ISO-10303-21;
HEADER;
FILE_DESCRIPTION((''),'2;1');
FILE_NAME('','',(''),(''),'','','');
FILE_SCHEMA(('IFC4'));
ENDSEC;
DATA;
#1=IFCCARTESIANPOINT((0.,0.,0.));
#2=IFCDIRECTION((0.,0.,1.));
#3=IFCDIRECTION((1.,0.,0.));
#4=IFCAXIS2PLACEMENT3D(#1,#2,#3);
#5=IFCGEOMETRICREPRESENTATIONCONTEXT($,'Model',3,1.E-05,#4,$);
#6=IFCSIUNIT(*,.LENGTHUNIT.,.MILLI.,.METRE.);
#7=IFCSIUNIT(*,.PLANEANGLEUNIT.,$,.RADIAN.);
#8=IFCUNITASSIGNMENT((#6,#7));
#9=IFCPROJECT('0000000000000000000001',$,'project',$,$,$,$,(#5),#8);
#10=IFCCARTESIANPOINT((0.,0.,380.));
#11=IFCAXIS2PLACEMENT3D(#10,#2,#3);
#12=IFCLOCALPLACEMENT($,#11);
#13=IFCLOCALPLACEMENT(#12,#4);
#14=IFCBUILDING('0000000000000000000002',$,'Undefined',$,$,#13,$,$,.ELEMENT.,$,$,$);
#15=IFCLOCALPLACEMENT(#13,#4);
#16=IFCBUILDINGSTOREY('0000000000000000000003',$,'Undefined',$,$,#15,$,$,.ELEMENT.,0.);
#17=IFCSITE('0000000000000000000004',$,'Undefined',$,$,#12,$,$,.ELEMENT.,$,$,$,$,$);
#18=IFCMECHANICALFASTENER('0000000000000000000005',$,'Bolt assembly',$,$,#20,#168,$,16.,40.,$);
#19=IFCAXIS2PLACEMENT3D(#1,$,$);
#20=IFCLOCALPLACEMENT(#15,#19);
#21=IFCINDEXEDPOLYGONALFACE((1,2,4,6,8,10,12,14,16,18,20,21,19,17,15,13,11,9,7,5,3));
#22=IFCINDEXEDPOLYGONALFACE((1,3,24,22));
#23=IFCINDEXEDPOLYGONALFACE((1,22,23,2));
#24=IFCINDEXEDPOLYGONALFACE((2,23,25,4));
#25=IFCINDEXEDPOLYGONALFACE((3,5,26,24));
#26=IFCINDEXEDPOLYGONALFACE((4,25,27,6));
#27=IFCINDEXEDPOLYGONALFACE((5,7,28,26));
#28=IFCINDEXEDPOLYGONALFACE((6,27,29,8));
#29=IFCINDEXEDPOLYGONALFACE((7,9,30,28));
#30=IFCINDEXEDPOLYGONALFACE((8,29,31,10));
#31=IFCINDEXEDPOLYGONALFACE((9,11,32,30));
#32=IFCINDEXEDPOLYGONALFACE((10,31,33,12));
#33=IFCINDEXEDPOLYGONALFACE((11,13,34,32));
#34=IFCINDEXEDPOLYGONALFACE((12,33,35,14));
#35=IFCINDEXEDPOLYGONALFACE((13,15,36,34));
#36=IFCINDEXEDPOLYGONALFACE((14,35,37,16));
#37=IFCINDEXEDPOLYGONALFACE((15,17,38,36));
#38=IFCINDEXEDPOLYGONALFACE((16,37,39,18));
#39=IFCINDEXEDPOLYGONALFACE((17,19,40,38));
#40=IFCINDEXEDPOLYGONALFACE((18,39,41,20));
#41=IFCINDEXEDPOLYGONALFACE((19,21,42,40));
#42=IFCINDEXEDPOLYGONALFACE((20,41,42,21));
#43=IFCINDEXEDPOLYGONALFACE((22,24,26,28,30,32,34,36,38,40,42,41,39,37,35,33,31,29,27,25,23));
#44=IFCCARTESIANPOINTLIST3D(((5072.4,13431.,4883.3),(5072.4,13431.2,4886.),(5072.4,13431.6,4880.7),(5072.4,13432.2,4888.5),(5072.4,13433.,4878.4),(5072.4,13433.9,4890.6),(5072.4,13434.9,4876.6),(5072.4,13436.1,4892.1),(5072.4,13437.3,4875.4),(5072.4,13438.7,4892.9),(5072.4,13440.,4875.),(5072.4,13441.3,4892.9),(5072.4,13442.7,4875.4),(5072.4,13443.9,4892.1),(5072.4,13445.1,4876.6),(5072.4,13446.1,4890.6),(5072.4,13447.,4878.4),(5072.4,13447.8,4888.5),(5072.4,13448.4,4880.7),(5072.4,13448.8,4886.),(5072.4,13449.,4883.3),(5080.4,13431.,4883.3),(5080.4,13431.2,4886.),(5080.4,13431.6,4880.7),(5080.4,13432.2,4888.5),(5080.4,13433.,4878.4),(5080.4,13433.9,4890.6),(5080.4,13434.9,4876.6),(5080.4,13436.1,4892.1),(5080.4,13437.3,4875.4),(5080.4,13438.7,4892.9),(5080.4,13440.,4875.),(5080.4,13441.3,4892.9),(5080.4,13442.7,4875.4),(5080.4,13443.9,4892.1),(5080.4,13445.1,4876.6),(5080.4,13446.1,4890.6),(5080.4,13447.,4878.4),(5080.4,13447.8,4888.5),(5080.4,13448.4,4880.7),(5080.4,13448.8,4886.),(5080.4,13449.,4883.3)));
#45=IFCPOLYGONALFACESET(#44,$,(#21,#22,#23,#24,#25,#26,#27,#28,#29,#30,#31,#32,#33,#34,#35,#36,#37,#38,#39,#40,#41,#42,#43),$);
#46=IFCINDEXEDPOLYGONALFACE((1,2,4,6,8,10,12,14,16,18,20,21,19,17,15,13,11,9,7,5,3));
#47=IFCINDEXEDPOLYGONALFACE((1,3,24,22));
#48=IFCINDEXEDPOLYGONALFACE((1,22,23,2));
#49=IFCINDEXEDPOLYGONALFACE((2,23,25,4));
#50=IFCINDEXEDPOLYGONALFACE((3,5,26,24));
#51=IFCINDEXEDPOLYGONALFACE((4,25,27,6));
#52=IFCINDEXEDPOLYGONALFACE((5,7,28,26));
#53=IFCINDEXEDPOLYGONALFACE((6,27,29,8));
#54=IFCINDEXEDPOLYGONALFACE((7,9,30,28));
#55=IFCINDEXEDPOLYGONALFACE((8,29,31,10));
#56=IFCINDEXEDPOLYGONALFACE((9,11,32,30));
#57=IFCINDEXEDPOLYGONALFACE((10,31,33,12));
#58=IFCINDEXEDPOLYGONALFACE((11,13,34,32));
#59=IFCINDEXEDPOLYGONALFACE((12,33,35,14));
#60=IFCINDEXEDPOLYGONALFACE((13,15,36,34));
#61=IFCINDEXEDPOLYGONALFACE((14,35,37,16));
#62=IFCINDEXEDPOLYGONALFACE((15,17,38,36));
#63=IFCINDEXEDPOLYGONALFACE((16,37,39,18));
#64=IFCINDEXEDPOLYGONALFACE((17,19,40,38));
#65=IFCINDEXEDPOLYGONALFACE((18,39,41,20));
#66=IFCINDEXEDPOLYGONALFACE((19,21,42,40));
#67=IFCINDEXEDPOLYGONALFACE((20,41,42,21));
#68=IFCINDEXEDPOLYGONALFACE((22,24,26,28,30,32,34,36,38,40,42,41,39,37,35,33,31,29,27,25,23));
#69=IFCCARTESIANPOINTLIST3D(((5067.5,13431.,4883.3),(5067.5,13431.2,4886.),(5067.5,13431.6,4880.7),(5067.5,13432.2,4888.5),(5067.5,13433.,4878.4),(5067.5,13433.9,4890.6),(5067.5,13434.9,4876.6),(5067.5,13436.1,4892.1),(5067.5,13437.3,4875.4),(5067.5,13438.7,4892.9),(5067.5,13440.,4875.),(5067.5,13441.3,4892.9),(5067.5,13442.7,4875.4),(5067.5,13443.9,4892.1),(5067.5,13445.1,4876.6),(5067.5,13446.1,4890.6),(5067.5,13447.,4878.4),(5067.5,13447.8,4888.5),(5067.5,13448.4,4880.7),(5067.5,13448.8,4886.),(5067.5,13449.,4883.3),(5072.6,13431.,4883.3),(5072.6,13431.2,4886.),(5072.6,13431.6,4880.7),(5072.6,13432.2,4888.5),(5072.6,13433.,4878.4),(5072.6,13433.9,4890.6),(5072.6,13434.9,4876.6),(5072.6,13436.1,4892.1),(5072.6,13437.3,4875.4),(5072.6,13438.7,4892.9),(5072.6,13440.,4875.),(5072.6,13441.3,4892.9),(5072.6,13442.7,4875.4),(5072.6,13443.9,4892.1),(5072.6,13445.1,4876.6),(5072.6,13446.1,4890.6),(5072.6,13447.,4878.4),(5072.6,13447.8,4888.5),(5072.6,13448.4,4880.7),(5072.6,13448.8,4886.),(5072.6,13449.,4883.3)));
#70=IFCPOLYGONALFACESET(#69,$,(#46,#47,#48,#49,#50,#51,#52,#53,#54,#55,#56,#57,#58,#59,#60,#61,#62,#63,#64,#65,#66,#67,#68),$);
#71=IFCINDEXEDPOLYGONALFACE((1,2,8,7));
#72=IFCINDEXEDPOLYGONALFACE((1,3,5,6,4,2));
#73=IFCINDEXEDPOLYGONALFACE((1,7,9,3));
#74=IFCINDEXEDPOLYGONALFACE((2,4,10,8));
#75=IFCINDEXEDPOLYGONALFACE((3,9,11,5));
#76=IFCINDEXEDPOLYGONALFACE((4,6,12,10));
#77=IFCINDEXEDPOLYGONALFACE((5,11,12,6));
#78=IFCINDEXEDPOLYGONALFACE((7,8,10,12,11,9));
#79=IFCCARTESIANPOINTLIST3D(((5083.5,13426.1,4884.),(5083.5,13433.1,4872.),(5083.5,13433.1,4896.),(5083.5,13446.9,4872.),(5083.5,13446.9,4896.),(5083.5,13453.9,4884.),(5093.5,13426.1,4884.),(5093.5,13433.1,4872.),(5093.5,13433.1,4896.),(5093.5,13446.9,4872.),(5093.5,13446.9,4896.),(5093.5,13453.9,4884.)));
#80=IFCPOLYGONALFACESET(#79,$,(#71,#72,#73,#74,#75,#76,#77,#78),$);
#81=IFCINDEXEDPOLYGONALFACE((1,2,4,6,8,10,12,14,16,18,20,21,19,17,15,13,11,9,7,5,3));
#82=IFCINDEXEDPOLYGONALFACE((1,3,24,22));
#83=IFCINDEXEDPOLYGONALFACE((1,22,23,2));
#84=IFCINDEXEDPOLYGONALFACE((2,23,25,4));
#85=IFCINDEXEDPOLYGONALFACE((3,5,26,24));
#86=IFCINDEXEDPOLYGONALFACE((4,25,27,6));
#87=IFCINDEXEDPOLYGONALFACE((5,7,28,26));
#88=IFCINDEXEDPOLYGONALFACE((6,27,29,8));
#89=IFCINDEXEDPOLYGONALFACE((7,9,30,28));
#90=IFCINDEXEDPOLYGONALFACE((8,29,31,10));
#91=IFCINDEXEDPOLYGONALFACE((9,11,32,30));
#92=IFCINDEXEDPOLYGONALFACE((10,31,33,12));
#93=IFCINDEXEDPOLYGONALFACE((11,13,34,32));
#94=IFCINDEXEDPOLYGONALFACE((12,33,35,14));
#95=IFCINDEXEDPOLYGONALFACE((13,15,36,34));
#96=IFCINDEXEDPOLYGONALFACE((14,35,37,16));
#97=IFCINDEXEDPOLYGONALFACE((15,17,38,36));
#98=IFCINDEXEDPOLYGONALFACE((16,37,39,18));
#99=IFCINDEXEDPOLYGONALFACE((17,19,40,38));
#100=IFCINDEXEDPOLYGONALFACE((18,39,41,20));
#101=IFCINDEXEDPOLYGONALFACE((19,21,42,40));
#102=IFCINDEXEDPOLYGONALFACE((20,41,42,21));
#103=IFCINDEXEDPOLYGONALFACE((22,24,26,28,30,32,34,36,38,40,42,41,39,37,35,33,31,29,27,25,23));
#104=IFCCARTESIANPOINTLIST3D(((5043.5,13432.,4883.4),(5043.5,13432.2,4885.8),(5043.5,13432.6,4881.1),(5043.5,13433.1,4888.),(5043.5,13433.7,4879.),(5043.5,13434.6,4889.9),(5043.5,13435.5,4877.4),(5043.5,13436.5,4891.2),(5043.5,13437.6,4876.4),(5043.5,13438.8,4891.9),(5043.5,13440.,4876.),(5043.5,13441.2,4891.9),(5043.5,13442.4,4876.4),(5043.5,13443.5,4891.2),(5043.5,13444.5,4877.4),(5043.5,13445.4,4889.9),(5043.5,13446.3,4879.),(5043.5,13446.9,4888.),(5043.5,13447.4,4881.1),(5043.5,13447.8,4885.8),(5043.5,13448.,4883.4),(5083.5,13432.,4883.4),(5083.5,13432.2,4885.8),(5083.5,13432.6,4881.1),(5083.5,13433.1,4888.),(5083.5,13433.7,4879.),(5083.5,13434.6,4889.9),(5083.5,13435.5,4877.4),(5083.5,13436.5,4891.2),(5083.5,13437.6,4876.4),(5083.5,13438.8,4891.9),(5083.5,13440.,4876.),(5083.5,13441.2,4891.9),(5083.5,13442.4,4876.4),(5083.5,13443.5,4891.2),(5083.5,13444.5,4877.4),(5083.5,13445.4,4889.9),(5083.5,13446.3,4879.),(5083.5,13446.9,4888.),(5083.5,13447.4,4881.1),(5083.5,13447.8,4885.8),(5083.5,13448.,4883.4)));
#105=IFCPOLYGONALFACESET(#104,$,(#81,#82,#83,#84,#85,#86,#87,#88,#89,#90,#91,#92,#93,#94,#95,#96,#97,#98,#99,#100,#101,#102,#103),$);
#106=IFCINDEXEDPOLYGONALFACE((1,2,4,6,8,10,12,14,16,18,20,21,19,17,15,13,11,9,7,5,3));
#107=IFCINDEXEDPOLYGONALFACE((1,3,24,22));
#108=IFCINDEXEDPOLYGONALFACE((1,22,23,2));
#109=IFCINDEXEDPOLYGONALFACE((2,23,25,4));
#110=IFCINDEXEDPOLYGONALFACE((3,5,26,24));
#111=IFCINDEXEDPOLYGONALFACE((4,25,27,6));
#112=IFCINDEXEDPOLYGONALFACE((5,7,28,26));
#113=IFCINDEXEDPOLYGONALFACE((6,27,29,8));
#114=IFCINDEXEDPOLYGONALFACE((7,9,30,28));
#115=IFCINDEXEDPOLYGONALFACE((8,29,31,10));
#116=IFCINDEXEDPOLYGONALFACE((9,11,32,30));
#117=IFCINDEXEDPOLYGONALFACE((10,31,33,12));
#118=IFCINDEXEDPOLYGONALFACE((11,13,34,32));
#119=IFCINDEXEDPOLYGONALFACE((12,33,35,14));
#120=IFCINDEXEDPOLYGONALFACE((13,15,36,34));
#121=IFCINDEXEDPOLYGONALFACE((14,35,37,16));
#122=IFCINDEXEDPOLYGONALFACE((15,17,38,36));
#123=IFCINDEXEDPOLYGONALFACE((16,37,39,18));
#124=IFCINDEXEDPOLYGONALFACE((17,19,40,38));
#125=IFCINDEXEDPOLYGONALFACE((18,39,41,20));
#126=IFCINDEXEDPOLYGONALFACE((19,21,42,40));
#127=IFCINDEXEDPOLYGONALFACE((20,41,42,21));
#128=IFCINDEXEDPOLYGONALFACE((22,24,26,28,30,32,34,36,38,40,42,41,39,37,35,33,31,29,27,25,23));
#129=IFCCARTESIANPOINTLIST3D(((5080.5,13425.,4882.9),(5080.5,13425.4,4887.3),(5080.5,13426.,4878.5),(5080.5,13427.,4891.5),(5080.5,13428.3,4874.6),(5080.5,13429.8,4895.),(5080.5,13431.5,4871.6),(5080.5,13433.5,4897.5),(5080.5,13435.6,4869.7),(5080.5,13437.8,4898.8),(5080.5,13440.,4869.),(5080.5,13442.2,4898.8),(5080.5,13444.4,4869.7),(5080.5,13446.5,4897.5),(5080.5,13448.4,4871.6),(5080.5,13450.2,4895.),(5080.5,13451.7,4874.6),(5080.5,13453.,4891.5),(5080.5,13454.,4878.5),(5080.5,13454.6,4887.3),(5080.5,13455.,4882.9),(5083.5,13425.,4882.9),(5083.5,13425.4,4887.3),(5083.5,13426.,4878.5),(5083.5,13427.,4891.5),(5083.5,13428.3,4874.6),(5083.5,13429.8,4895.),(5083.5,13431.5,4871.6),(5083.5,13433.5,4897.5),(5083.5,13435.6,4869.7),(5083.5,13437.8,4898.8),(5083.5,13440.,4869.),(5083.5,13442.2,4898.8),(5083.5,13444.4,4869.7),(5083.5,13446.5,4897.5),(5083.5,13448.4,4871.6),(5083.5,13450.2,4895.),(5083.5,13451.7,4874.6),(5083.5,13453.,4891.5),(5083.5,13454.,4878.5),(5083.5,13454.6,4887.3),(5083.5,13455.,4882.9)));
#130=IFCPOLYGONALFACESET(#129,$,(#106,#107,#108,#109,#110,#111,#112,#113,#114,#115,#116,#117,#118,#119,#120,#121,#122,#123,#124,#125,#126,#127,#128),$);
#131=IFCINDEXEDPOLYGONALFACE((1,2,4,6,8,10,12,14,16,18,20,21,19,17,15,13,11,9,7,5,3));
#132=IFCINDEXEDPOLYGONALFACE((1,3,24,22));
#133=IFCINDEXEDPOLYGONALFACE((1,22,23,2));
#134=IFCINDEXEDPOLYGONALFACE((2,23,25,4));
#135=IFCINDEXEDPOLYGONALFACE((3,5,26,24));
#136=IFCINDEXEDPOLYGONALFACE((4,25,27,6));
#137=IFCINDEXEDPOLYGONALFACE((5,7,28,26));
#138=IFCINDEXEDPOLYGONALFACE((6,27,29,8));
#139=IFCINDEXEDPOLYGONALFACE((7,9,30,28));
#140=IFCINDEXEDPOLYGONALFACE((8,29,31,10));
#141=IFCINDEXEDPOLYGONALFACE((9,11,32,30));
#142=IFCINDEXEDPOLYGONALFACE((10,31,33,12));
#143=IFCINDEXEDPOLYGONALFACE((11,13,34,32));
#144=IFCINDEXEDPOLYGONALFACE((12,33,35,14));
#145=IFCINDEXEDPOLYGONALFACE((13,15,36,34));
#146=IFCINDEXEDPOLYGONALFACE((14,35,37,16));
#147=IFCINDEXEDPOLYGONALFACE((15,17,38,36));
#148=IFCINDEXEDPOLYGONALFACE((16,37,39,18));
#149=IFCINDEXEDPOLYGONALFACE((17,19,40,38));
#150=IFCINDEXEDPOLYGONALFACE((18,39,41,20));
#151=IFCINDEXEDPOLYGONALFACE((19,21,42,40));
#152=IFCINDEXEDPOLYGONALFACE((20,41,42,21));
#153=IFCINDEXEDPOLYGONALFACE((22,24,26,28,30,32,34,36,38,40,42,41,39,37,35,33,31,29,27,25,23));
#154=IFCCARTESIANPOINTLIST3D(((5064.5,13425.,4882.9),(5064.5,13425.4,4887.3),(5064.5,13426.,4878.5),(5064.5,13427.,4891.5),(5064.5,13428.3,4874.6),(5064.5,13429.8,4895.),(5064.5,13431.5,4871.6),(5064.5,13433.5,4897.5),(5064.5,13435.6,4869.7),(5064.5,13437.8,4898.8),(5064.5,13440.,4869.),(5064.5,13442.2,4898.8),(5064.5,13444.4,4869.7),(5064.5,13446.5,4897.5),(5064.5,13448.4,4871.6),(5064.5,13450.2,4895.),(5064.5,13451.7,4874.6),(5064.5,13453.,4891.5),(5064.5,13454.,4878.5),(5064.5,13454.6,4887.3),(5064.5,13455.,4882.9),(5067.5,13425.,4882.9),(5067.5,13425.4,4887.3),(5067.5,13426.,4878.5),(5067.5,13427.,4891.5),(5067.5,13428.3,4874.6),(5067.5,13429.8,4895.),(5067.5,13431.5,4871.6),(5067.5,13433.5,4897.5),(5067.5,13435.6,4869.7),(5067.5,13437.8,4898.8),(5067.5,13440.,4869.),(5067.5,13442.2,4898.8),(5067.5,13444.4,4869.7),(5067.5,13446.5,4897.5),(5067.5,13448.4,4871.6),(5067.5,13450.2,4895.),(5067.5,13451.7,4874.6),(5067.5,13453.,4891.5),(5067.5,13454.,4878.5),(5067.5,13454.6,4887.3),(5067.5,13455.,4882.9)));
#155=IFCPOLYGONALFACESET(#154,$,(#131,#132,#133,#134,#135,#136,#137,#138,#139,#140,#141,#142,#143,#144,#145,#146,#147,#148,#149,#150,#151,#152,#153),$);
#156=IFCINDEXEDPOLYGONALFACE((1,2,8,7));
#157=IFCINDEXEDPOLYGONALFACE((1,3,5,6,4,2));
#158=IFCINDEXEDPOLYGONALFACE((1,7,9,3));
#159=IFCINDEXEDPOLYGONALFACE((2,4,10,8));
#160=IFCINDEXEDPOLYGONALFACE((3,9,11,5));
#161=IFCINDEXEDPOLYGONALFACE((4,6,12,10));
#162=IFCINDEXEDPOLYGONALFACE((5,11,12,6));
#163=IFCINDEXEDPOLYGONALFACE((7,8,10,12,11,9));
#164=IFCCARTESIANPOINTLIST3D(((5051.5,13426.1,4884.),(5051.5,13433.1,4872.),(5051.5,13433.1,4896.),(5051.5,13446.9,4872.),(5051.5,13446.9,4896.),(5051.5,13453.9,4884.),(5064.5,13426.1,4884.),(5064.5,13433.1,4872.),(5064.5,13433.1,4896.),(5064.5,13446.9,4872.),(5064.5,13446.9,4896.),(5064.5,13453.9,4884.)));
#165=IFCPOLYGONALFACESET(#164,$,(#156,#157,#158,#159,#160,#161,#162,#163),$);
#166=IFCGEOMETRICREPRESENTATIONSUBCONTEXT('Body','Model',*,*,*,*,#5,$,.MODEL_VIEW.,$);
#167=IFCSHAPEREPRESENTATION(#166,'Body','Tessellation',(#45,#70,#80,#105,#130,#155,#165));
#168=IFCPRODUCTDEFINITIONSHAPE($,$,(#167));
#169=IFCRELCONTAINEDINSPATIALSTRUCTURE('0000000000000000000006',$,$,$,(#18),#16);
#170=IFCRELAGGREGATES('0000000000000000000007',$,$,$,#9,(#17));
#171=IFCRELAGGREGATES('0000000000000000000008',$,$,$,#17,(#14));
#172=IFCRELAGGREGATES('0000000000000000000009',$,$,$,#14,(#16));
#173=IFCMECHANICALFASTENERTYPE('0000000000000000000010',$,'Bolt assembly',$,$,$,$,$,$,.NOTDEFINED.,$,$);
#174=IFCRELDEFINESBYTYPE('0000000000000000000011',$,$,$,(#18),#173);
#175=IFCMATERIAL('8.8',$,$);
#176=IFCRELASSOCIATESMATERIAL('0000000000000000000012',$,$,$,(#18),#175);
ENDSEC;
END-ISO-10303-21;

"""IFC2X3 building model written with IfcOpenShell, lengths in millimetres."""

from ifc_helpers import new_model, si_unit, frame, origin_with_axes, origin_2d_with_axis, place, context, subcontext, project, spatial, polyline, circle, outline, extrude, source, transform, mapped, material, type_object, element, save


model = new_model("IFC2X3")

# Units and contexts
model_context = context("Model", 3, precision=1e-05, world=origin_with_axes())
body_context = subcontext(model_context, "Body", "Model", "MODEL_VIEW")
ifc_project = project(units=[si_unit("LENGTHUNIT", "METRE", prefix="MILLI"), si_unit("PLANEANGLEUNIT", "RADIAN")], contexts=[model_context])

# Site, building, storey
site_placement = place(None, frame((0.0, 0.0, 380.0), z_axis=(0.0, 0.0, 1.0), x_axis=(1.0, 0.0, 0.0)))
site = spatial("IfcSite", under=ifc_project, at=site_placement, Name="Undefined", CompositionType="ELEMENT")
building_placement = place(site_placement, origin_with_axes())
building = spatial("IfcBuilding", under=site, at=building_placement, Name="Undefined", CompositionType="ELEMENT")
storey_placement = place(building_placement, origin_with_axes())
storey = spatial("IfcBuildingStorey", under=building, at=storey_placement, Name="Undefined", CompositionType="ELEMENT", Elevation=0.0)

# Mechanical fastener
ifc_material_1 = material(Name="8.8")
mechanical_fastener_type = type_object("IfcMechanicalFastenerType", Name="Bolt assembly")
shared_shape_1 = source(origin_with_axes(), body_context, "Body", "SweptSolid", [
    extrude(circle(Radius=9.0, at=origin_2d_with_axis()), frame((0.0, -7.9, 0.0), z_axis=(0.0, 1.0, 0.0), x_axis=(1.0, 0.0, 0.0)), (0.0, 0.0, 1.0), 8.0),
    extrude(circle(Radius=9.0, at=origin_2d_with_axis()), frame((0.0, -0.1, 0.0), z_axis=(0.0, 1.0, 0.0), x_axis=(1.0, 0.0, 0.0)), (0.0, 0.0, 1.0), 5.1),
    extrude(outline(polyline([(12.0, -6.9), (12.0, 6.9), (0.0, 13.9), (-12.0, 6.9), (-12.0, -6.9), (0.0, -13.9), (12.0, -6.9)])), frame((0.0, -21.0, 0.0), z_axis=(0.0, 1.0, 0.0), x_axis=(1.0, 0.0, 0.0)), (0.0, 0.0, 1.0), 10.0),
    extrude(circle(Radius=8.0, at=origin_2d_with_axis()), frame((0.0, -11.0, 0.0), z_axis=(0.0, 1.0, 0.0), x_axis=(1.0, 0.0, 0.0)), (0.0, 0.0, 1.0), 40.0),
    extrude(circle(Radius=15.0, at=origin_2d_with_axis()), frame((0.0, -11.0, 0.0), z_axis=(0.0, 1.0, 0.0), x_axis=(1.0, 0.0, 0.0)), (0.0, 0.0, 1.0), 3.0),
    extrude(circle(Radius=15.0, at=origin_2d_with_axis()), frame((0.0, 5.0, 0.0), z_axis=(0.0, 1.0, 0.0), x_axis=(1.0, 0.0, 0.0)), (0.0, 0.0, 1.0), 3.0),
    extrude(outline(polyline([(12.0, -6.9), (12.0, 6.9), (0.0, 13.9), (-12.0, 6.9), (-12.0, -6.9), (0.0, -13.9), (12.0, -6.9)])), frame((0.0, 8.0, 0.0), z_axis=(0.0, 1.0, 0.0), x_axis=(1.0, 0.0, 0.0)), (0.0, 0.0, 1.0), 13.0),
])
for number, where, z_axis, x_axis, name in (
    (1, (5072.5, 13402.5, 4964.0), (0.0, 1.0, 0.0), (0.0, 0.0, -1.0), "Bolt assembly"),
):
    element("IfcMechanicalFastener", number, at=place(storey_placement, frame(where, z_axis=z_axis, x_axis=x_axis)), inside=storey, type_object=mechanical_fastener_type, material=ifc_material_1, Name=name, NominalDiameter=16.0, NominalLength=40.0, context=body_context, shape_type="MappedRepresentation", body=[
        mapped(shared_shape_1, transform((80.0, 0.0, 37.5))),
    ])

save(model, "model.ifc")
